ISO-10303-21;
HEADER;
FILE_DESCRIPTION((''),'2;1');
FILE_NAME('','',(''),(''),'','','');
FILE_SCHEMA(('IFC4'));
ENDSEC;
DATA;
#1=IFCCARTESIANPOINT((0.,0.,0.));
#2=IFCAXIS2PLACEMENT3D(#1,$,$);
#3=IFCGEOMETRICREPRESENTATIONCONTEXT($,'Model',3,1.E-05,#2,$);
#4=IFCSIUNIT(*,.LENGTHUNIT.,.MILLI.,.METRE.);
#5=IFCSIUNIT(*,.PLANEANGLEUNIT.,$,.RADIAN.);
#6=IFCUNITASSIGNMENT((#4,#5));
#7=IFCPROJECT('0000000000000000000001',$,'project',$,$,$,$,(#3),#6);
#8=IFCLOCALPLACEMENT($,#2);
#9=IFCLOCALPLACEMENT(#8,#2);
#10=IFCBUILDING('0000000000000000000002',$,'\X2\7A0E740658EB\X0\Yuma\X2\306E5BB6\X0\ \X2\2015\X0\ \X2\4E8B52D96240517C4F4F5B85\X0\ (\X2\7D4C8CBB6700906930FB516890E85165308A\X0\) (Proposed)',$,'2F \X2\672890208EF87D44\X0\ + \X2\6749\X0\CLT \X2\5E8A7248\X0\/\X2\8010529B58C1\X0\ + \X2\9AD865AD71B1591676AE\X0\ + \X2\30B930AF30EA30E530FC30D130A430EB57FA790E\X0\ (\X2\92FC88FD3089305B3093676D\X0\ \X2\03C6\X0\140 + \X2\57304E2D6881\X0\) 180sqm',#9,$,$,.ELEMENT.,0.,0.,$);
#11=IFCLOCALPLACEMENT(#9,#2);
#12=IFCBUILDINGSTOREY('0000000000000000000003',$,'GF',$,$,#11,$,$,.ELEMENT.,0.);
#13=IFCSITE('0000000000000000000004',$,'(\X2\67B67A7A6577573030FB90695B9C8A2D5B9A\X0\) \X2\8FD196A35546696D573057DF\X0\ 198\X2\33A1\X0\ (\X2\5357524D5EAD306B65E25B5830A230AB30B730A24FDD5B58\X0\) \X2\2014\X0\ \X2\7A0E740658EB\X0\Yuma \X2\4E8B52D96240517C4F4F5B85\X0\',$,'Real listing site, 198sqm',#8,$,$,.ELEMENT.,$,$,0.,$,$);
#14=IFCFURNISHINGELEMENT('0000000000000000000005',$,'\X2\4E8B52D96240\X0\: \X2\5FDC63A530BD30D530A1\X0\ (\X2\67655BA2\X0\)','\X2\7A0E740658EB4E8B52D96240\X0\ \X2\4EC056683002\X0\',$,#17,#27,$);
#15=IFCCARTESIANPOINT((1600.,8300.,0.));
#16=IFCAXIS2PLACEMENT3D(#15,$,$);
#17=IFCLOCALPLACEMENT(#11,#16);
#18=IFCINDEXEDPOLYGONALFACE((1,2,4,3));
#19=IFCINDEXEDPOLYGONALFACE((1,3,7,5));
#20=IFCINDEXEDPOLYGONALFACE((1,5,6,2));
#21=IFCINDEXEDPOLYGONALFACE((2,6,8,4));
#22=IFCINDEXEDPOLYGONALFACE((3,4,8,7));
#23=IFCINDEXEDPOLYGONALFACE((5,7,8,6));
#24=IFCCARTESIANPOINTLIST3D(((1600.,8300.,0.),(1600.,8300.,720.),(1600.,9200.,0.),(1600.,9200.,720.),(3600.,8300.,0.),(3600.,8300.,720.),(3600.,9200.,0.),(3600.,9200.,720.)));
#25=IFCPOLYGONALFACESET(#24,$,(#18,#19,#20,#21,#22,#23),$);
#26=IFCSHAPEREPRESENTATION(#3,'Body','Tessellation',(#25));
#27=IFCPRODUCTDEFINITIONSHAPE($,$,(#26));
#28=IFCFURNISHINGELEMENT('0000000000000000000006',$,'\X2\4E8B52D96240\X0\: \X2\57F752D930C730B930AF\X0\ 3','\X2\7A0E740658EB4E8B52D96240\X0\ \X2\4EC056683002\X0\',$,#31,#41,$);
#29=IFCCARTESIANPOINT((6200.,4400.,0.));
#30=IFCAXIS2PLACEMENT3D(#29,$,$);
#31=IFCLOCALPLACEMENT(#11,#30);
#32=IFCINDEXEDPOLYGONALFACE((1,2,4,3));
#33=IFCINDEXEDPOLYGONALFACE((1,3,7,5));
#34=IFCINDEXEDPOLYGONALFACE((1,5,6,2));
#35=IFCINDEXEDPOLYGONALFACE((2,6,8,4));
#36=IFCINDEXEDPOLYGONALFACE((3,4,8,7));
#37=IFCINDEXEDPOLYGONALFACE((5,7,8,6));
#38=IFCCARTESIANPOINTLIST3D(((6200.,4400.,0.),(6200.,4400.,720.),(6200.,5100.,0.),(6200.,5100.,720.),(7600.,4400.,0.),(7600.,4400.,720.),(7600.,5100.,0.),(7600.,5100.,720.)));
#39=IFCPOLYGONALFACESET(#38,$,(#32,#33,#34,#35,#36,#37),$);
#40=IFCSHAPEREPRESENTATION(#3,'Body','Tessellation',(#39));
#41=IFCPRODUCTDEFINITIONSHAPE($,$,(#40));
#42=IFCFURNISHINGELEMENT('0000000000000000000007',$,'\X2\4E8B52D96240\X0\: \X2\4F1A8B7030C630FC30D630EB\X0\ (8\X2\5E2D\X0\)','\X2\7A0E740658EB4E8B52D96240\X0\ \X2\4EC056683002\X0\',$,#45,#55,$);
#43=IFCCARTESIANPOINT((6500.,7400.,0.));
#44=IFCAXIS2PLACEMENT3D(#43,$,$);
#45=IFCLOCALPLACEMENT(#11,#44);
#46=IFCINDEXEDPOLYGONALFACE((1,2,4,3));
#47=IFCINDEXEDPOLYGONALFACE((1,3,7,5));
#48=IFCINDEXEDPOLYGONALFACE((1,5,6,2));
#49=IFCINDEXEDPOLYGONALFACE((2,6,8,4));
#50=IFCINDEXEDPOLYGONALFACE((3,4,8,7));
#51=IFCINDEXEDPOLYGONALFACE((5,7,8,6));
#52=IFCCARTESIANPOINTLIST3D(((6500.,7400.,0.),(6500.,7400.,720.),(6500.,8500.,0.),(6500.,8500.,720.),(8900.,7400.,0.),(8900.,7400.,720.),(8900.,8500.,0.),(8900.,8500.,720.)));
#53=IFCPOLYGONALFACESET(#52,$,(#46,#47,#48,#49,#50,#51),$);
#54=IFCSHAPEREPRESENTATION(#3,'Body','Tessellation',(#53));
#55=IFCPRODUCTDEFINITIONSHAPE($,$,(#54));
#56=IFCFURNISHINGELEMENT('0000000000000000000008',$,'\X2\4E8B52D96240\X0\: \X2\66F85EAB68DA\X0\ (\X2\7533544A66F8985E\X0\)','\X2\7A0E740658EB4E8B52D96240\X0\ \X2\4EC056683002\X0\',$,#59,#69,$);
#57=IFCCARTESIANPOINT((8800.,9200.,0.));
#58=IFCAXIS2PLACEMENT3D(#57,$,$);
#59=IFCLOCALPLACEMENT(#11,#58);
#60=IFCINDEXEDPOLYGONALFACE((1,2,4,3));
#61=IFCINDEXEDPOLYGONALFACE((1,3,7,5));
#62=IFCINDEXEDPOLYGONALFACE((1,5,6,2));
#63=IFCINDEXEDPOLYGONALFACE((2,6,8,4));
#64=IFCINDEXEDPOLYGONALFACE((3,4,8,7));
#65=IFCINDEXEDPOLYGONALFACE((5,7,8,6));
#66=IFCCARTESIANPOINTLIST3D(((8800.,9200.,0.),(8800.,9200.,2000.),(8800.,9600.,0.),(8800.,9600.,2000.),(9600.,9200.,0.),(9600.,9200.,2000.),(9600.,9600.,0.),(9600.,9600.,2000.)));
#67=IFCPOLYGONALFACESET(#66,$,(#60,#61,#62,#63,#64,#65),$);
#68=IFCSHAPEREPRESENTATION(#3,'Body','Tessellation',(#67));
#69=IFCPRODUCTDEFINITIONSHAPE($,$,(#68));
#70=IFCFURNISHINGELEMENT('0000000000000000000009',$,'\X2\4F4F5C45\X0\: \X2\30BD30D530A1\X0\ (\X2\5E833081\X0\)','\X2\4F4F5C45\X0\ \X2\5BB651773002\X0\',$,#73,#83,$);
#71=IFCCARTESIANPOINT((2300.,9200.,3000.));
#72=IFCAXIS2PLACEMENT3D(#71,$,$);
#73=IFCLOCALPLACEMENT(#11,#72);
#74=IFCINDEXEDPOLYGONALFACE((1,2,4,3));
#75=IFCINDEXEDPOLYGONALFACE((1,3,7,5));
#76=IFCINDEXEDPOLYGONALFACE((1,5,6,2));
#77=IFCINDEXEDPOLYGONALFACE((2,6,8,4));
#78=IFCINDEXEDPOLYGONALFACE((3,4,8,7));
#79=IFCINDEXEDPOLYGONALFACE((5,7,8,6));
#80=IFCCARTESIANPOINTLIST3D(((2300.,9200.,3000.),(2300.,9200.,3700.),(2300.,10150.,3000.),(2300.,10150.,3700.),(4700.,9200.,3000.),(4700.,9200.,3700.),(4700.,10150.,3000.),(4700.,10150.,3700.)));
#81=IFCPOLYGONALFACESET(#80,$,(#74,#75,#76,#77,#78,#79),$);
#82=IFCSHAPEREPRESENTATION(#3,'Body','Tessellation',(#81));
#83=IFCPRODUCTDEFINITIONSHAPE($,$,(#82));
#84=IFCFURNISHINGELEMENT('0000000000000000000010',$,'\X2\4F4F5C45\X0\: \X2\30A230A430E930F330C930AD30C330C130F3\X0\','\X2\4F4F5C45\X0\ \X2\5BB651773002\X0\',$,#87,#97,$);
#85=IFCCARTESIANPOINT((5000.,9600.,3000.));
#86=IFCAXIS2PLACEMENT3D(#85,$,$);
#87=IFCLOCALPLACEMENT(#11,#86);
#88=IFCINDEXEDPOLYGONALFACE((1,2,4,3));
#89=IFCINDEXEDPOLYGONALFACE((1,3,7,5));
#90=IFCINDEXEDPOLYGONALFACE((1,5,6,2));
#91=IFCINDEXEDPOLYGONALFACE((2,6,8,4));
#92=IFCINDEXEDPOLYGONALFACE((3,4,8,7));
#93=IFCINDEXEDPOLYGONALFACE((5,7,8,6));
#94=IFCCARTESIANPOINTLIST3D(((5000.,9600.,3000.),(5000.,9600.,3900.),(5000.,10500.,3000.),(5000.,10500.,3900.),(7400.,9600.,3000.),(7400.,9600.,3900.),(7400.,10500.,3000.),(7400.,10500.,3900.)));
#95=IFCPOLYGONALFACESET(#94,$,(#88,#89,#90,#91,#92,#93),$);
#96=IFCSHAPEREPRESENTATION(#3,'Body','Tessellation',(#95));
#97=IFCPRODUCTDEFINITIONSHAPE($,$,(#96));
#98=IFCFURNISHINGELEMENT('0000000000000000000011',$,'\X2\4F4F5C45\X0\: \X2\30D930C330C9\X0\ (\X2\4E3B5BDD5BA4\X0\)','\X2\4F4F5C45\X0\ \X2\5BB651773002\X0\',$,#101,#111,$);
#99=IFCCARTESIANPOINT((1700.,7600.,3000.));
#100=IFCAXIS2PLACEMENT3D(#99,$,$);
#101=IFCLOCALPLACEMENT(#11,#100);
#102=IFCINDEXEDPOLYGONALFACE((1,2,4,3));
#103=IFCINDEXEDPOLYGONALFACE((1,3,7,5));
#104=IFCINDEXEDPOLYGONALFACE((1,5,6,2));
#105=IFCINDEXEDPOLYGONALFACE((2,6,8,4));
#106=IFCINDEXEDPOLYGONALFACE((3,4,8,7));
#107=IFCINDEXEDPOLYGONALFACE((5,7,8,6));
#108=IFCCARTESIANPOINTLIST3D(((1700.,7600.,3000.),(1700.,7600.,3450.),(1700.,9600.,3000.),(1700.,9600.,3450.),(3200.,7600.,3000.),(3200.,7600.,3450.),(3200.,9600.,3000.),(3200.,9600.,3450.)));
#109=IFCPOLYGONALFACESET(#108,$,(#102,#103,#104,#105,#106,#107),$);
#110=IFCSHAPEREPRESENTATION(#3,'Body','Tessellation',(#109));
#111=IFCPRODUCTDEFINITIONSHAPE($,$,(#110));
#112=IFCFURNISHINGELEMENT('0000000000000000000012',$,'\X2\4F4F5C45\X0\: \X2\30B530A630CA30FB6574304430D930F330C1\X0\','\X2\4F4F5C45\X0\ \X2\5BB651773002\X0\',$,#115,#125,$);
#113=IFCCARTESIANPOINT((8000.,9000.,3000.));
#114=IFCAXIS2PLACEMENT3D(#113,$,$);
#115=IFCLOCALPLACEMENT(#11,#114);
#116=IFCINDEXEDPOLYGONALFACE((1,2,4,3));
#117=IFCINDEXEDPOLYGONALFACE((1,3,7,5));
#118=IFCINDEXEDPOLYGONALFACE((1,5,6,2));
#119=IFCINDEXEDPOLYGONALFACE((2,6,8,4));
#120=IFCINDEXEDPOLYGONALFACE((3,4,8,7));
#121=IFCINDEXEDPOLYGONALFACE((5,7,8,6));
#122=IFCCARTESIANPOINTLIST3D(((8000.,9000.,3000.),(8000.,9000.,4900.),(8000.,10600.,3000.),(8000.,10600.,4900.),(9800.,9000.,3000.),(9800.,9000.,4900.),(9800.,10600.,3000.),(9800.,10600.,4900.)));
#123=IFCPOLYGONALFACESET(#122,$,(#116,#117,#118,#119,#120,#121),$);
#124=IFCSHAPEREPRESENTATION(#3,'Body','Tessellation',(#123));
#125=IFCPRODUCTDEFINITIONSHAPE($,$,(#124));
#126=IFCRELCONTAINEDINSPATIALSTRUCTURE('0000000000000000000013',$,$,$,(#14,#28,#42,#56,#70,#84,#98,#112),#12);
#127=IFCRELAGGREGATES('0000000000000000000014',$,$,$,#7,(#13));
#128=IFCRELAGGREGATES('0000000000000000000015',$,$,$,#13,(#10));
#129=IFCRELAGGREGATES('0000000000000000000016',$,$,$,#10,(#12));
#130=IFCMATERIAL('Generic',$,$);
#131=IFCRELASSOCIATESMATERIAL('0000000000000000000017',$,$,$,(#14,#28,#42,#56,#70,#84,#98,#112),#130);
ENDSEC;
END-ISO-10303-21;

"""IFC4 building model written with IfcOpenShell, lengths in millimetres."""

from ifc_helpers import new_model, si_unit, frame, frame_2d, origin, place, context, project, spatial, rectangle, extrude, material, element, save


model = new_model("IFC4")

# Units and contexts
model_context = context("Model", 3, precision=1e-05, world=origin())
ifc_project = project(units=[si_unit("LENGTHUNIT", "METRE", prefix="MILLI"), si_unit("PLANEANGLEUNIT", "RADIAN")], contexts=[model_context])

# Site, building, storey
site_placement = place(None, origin())
site = spatial("IfcSite", under=ifc_project, at=site_placement, Name="(架空敷地・適宜設定) 近隣商業地域 198㎡ (南前庭に既存アカシア保存) — 税理士Yuma 事務所兼住宅", ObjectType="Real listing site, 198sqm", CompositionType="ELEMENT", RefElevation=0.0)
building_placement = place(site_placement, origin())
building = spatial("IfcBuilding", under=site, at=building_placement, Name="税理士Yumaの家 ― 事務所兼住宅 (経費最適・全部入り) (Proposed)", ObjectType="2F 木造軸組 + 杉CLT 床版/耐力壁 + 高断熱外皮 + スクリューパイル基礎 (鋼製らせん杭 φ140 + 地中梁) 180sqm", CompositionType="ELEMENT", ElevationOfRefHeight=0.0, ElevationOfTerrain=0.0)
storey_placement = place(building_placement, origin())
storey = spatial("IfcBuildingStorey", under=building, at=storey_placement, Name="GF", CompositionType="ELEMENT", Elevation=0.0)

# Shared definitions
ifc_material_1 = material(Name="Generic")

# Furnishing elements
furnishing_1_placement = place(storey_placement, frame((1600.0, 8300.0, 0.0)))
element("IfcFurnishingElement", 1, at=furnishing_1_placement, inside=storey, material=ifc_material_1, Name="事務所: 応接ソファ (来客)", Description="税理士事務所 什器。", context=model_context, shape_type="SweptSolid", body=[
    extrude(rectangle(XDim=2000.0, YDim=900.0, at=frame_2d((1000.0, 450.0))), frame((1600.0, 8300.0, 0.0)), (0.0, 0.0, 1.0), 720.0),
])
furnishing_2_placement = place(storey_placement, frame((6200.0, 4400.0, 0.0)))
element("IfcFurnishingElement", 2, at=furnishing_2_placement, inside=storey, material=ifc_material_1, Name="事務所: 執務デスク 3", Description="税理士事務所 什器。", context=model_context, shape_type="SweptSolid", body=[
    extrude(rectangle(XDim=1400.0, YDim=700.0, at=frame_2d((700.0, 350.0))), frame((6200.0, 4400.0, 0.0)), (0.0, 0.0, 1.0), 720.0),
])
furnishing_3_placement = place(storey_placement, frame((6500.0, 7400.0, 0.0)))
element("IfcFurnishingElement", 3, at=furnishing_3_placement, inside=storey, material=ifc_material_1, Name="事務所: 会議テーブル (8席)", Description="税理士事務所 什器。", context=model_context, shape_type="SweptSolid", body=[
    extrude(rectangle(XDim=2400.0, YDim=1100.0, at=frame_2d((1200.0, 550.0))), frame((6500.0, 7400.0, 0.0)), (0.0, 0.0, 1.0), 720.0),
])
furnishing_4_placement = place(storey_placement, frame((8800.0, 9200.0, 0.0)))
element("IfcFurnishingElement", 4, at=furnishing_4_placement, inside=storey, material=ifc_material_1, Name="事務所: 書庫棚 (申告書類)", Description="税理士事務所 什器。", context=model_context, shape_type="SweptSolid", body=[
    extrude(rectangle(XDim=800.0, YDim=400.0, at=frame_2d((400.0, 200.0))), frame((8800.0, 9200.0, 0.0)), (0.0, 0.0, 1.0), 2000.0),
])
furnishing_5_placement = place(storey_placement, frame((2300.0, 9200.0, 3000.0)))
element("IfcFurnishingElement", 5, at=furnishing_5_placement, inside=storey, material=ifc_material_1, Name="住居: ソファ (広め)", Description="住居 家具。", context=model_context, shape_type="SweptSolid", body=[
    extrude(rectangle(XDim=2400.0, YDim=950.0, at=frame_2d((1200.0, 475.0))), frame((2300.0, 9200.0, 3000.0)), (0.0, 0.0, 1.0), 700.0),
])
furnishing_6_placement = place(storey_placement, frame((5000.0, 9600.0, 3000.0)))
element("IfcFurnishingElement", 6, at=furnishing_6_placement, inside=storey, material=ifc_material_1, Name="住居: アイランドキッチン", Description="住居 家具。", context=model_context, shape_type="SweptSolid", body=[
    extrude(rectangle(XDim=2400.0, YDim=900.0, at=frame_2d((1200.0, 450.0))), frame((5000.0, 9600.0, 3000.0)), (0.0, 0.0, 1.0), 900.0),
])
furnishing_7_placement = place(storey_placement, frame((1700.0, 7600.0, 3000.0)))
element("IfcFurnishingElement", 7, at=furnishing_7_placement, inside=storey, material=ifc_material_1, Name="住居: ベッド (主寝室)", Description="住居 家具。", context=model_context, shape_type="SweptSolid", body=[
    extrude(rectangle(XDim=1500.0, YDim=2000.0, at=frame_2d((750.0, 1000.0))), frame((1700.0, 7600.0, 3000.0)), (0.0, 0.0, 1.0), 450.0),
])
furnishing_8_placement = place(storey_placement, frame((8000.0, 9000.0, 3000.0)))
element("IfcFurnishingElement", 8, at=furnishing_8_placement, inside=storey, material=ifc_material_1, Name="住居: サウナ・整いベンチ", Description="住居 家具。", context=model_context, shape_type="SweptSolid", body=[
    extrude(rectangle(XDim=1800.0, YDim=1600.0, at=frame_2d((900.0, 800.0))), frame((8000.0, 9000.0, 3000.0)), (0.0, 0.0, 1.0), 1900.0),
])

save(model, "model.ifc")
